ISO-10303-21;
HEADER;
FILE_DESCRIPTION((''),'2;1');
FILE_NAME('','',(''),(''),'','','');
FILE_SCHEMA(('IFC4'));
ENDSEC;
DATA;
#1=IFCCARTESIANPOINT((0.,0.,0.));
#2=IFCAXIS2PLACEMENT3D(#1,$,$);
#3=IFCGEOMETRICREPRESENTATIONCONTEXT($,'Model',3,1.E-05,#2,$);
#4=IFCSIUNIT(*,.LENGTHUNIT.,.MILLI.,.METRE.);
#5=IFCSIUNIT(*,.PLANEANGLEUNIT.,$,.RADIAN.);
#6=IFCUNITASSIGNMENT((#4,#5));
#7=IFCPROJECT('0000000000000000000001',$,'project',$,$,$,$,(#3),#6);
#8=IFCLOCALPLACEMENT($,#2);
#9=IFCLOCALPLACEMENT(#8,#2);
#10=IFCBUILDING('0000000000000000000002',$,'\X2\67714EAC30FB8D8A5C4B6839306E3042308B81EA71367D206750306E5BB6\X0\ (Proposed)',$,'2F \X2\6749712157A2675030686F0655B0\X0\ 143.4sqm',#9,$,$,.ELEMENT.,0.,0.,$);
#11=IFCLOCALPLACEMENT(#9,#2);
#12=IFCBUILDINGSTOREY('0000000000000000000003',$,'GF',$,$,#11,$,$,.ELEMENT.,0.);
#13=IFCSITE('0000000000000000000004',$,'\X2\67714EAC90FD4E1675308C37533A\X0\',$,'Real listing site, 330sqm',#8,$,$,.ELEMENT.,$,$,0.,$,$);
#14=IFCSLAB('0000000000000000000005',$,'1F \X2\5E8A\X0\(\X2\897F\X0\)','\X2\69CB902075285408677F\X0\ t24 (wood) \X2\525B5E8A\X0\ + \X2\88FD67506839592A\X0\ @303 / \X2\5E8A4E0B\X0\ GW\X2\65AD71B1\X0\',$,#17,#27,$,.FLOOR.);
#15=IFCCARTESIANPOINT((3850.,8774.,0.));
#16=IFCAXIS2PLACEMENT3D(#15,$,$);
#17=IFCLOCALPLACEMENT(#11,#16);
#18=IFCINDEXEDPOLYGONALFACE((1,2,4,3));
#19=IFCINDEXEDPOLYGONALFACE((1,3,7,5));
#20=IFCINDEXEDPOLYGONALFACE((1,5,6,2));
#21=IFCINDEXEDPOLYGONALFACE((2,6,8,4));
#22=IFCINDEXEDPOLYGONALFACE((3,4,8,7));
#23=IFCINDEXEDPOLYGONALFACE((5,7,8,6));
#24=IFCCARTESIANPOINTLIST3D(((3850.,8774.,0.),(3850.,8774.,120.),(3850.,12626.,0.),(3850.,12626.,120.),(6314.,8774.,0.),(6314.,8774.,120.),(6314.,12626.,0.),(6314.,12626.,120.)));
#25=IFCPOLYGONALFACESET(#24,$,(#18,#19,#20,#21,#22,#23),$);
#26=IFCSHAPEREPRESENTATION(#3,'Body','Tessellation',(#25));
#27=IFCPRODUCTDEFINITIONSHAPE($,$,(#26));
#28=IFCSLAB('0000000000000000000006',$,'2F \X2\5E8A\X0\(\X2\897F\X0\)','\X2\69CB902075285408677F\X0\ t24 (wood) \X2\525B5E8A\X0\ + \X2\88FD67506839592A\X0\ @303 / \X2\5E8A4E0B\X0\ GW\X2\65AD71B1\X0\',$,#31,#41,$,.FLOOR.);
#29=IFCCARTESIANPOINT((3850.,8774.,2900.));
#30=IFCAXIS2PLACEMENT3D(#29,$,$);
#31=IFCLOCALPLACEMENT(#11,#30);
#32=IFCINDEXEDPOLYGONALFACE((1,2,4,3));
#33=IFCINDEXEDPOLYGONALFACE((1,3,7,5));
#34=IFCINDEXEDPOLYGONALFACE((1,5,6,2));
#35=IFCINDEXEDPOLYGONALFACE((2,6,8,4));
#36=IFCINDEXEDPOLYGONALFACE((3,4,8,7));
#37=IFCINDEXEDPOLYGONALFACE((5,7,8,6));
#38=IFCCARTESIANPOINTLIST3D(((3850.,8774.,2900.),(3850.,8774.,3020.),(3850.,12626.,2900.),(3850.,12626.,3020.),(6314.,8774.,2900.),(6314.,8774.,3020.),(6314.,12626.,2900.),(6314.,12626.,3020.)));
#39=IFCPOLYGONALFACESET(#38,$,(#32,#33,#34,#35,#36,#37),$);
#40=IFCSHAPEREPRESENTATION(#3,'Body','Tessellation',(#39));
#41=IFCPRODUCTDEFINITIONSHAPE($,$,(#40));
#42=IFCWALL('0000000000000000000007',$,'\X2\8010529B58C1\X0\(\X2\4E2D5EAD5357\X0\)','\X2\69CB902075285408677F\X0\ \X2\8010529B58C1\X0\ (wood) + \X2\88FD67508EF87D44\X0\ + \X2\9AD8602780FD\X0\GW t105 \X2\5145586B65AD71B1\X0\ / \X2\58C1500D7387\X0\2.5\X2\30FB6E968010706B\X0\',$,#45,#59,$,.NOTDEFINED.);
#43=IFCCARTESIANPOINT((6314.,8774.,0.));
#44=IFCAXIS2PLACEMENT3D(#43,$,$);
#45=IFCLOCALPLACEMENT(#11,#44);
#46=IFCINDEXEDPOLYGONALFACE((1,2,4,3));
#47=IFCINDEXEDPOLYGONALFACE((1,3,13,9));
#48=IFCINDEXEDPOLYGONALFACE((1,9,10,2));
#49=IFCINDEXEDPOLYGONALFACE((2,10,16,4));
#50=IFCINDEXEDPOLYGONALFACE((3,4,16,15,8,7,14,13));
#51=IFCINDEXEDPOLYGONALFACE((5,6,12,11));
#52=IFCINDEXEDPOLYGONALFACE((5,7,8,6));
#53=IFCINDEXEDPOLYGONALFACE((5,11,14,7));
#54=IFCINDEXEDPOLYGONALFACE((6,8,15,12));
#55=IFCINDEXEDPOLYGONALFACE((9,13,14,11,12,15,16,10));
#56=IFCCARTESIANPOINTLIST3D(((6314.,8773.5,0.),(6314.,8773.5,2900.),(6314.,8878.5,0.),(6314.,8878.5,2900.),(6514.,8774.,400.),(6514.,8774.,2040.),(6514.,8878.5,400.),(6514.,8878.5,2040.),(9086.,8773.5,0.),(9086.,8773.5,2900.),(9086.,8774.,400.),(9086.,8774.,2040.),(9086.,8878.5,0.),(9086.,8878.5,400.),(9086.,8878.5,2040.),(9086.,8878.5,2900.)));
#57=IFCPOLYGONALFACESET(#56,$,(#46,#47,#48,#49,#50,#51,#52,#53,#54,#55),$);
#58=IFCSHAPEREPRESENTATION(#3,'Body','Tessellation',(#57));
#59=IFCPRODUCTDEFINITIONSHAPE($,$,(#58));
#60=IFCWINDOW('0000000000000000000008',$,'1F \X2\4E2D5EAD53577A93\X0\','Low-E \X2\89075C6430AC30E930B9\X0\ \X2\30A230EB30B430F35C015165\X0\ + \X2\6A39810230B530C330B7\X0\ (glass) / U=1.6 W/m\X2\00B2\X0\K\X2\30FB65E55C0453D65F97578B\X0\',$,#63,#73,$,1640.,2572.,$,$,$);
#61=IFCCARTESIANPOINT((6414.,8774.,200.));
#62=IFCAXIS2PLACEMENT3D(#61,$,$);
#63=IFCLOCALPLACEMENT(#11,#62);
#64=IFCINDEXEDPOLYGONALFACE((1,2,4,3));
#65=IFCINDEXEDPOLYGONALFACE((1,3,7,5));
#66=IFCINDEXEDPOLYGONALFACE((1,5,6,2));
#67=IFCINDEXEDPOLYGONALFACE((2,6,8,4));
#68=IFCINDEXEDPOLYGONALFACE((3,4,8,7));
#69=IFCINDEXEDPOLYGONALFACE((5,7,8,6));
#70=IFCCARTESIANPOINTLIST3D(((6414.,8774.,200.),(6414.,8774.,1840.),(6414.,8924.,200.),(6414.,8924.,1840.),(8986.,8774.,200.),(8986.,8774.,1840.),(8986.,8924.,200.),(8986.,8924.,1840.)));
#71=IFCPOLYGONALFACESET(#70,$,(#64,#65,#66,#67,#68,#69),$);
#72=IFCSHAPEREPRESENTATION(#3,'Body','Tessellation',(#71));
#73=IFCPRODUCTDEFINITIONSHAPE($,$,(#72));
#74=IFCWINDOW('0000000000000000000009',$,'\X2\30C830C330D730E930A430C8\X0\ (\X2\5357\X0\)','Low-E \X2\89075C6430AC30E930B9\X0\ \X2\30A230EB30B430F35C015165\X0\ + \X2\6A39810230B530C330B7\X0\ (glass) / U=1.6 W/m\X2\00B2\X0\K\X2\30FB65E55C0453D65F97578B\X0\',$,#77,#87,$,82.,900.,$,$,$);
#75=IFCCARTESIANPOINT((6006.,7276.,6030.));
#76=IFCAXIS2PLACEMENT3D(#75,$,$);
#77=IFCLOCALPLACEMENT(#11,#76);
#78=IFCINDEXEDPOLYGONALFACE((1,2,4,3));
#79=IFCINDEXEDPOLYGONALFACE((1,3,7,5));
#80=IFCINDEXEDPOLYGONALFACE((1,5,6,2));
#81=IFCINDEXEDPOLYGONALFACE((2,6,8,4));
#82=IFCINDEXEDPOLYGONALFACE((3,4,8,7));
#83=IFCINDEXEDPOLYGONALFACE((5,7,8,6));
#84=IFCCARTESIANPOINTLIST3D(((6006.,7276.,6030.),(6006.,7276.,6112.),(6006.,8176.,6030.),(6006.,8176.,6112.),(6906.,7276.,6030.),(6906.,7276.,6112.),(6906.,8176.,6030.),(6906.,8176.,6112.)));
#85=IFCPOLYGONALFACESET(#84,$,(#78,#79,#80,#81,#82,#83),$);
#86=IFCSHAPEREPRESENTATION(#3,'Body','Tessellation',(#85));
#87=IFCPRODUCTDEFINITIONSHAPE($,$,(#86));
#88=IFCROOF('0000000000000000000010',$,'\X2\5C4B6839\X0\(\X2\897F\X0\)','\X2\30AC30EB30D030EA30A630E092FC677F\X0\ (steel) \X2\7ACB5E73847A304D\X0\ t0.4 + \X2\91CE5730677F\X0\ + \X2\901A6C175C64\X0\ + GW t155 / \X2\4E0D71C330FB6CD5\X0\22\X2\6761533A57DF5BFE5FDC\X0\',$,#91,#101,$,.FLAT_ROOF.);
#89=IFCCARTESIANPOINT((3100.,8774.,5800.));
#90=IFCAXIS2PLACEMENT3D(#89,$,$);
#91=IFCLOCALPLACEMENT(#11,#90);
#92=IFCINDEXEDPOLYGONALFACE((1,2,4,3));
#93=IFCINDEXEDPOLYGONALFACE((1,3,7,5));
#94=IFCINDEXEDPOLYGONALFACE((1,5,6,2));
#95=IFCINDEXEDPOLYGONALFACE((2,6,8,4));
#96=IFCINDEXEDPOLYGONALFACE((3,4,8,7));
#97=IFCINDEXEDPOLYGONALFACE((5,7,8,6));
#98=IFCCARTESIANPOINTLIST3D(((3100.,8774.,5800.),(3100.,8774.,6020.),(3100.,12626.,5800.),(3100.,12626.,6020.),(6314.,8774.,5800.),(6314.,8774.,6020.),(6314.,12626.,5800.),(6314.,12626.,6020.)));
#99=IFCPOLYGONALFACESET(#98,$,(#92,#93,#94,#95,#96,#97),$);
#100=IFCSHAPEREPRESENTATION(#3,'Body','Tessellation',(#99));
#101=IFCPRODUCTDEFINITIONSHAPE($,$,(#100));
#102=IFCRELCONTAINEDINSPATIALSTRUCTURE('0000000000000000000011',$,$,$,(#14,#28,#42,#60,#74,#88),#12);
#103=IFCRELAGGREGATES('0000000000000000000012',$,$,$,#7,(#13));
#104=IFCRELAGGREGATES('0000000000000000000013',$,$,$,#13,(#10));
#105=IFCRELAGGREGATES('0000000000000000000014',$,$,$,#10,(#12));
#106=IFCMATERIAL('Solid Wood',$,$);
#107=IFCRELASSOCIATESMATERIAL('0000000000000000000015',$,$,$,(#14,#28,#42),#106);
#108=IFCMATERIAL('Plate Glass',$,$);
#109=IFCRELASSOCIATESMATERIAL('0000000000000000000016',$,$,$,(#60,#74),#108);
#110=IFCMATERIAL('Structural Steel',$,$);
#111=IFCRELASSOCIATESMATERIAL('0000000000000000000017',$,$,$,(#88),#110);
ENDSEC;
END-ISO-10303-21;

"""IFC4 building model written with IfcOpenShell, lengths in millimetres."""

from ifc_helpers import new_model, si_unit, frame, frame_2d, origin, place, context, project, spatial, rectangle, extrude, material, element, fill, save


model = new_model("IFC4")

# Units and contexts
model_context = context("Model", 3, precision=1e-05, world=origin())
ifc_project = project(units=[si_unit("LENGTHUNIT", "METRE", prefix="MILLI"), si_unit("PLANEANGLEUNIT", "RADIAN")], contexts=[model_context])

# Site, building, storey
site_placement = place(None, origin())
site = spatial("IfcSite", under=ifc_project, at=site_placement, Name="東京都世田谷区", ObjectType="Real listing site, 330sqm", CompositionType="ELEMENT", RefElevation=0.0)
building_placement = place(site_placement, origin())
building = spatial("IfcBuilding", under=site, at=building_placement, Name="東京・越屋根のある自然素材の家 (Proposed)", ObjectType="2F 杉無垢材と漆喰 143.4sqm", CompositionType="ELEMENT", ElevationOfRefHeight=0.0, ElevationOfTerrain=0.0)
storey_placement = place(building_placement, origin())
storey = spatial("IfcBuildingStorey", under=building, at=storey_placement, Name="GF", CompositionType="ELEMENT", Elevation=0.0)

# Shared definitions
ifc_material_1 = material(Name="Solid Wood")

# Slabs
slab_1_placement = place(storey_placement, frame((3850.0, 8774.0, 0.0)))
element("IfcSlab", 1, at=slab_1_placement, inside=storey, material=ifc_material_1, Name="1F 床(西)", Description="構造用合板 t24 (wood) 剛床 + 製材根太 @303 / 床下 GW断熱", PredefinedType="FLOOR", context=model_context, shape_type="SweptSolid", body=[
    extrude(rectangle(XDim=2464.0, YDim=3852.0, at=frame_2d((1232.0, 1926.0))), frame((3850.0, 8774.0, 0.0)), (0.0, 0.0, 1.0), 120.0),
])
slab_2_placement = place(storey_placement, frame((3850.0, 8774.0, 2900.0)))
element("IfcSlab", 2, at=slab_2_placement, inside=storey, material=ifc_material_1, Name="2F 床(西)", Description="構造用合板 t24 (wood) 剛床 + 製材根太 @303 / 床下 GW断熱", PredefinedType="FLOOR", context=model_context, shape_type="SweptSolid", body=[
    extrude(rectangle(XDim=2464.0, YDim=3852.0, at=frame_2d((1232.0, 1926.0))), frame((3850.0, 8774.0, 2900.0)), (0.0, 0.0, 1.0), 120.0),
])

# Wall, opening, window
wall_placement = place(storey_placement, frame((6314.0, 8774.0, 0.0)))
wall = element("IfcWall", 3, at=wall_placement, inside=storey, material=ifc_material_1, Name="耐力壁(中庭南)", Description="構造用合板 耐力壁 (wood) + 製材軸組 + 高性能GW t105 充填断熱 / 壁倍率2.5・準耐火", PredefinedType="NOTDEFINED", context=model_context, shape_type="SweptSolid", body=[
    extrude(rectangle(XDim=2772.0, YDim=105.0, at=frame_2d((1386.0, 52.0))), frame((6314.0, 8774.0, 0.0)), (0.0, 0.0, 1.0), 2900.0),
])
opening_placement = place(storey_placement, frame((6414.0, 8774.0, 200.0)))
opening = element("IfcOpeningElement", 4, at=opening_placement, cuts=wall, PredefinedType="NOTDEFINED", context=model_context, shape_type="SweptSolid", body=[
    extrude(rectangle(XDim=2572.0, YDim=150.0, at=frame_2d((1286.0, 75.0))), frame((6414.0, 8774.0, 200.0)), (0.0, 0.0, 1.0), 1640.0),
])
ifc_material_2 = material(Name="Plate Glass")
window_1_placement = place(storey_placement, frame((6414.0, 8774.0, 200.0)))
window_1 = element("IfcWindow", 5, at=window_1_placement, inside=storey, material=ifc_material_2, Name="1F 中庭南窓", Description="Low-E 複層ガラス アルゴン封入 + 樹脂サッシ (glass) / U=1.6 W/m²K・日射取得型", OverallHeight=1640.0, OverallWidth=2572.0, context=model_context, shape_type="SweptSolid", body=[
    extrude(rectangle(XDim=2572.0, YDim=150.0, at=frame_2d((1286.0, 75.0))), frame((6414.0, 8774.0, 200.0)), (0.0, 0.0, 1.0), 1640.0),
])
fill(opening, window_1)

# Window
window_2_placement = place(storey_placement, frame((6006.0, 7276.0, 6030.0)))
element("IfcWindow", 6, at=window_2_placement, inside=storey, material=ifc_material_2, Name="トップライト (南)", Description="Low-E 複層ガラス アルゴン封入 + 樹脂サッシ (glass) / U=1.6 W/m²K・日射取得型", OverallHeight=82.0, OverallWidth=900.0, context=model_context, shape_type="SweptSolid", body=[
    extrude(rectangle(XDim=900.0, YDim=900.0, at=frame_2d((450.0, 450.0))), frame((6006.0, 7276.0, 6030.0)), (0.0, 0.0, 1.0), 82.0),
])

# Roof
ifc_material_3 = material(Name="Structural Steel")
for number, where, name in (
    (7, (3100.0, 8774.0, 5800.0), "屋根(西)"),
):
    element("IfcRoof", number, at=place(storey_placement, frame(where)), inside=storey, material=ifc_material_3, Name=name, Description="ガルバリウム鋼板 (steel) 立平葺き t0.4 + 野地板 + 通気層 + GW t155 / 不燃・法22条区域対応", PredefinedType="FLAT_ROOF", context=model_context, shape_type="SweptSolid", body=[
        extrude(rectangle(XDim=3214.0, YDim=3852.0, at=frame_2d((1607.0, 1926.0))), frame((3100.0, 8774.0, 5800.0)), (0.0, 0.0, 1.0), 220.0),
    ])

save(model, "model.ifc")
